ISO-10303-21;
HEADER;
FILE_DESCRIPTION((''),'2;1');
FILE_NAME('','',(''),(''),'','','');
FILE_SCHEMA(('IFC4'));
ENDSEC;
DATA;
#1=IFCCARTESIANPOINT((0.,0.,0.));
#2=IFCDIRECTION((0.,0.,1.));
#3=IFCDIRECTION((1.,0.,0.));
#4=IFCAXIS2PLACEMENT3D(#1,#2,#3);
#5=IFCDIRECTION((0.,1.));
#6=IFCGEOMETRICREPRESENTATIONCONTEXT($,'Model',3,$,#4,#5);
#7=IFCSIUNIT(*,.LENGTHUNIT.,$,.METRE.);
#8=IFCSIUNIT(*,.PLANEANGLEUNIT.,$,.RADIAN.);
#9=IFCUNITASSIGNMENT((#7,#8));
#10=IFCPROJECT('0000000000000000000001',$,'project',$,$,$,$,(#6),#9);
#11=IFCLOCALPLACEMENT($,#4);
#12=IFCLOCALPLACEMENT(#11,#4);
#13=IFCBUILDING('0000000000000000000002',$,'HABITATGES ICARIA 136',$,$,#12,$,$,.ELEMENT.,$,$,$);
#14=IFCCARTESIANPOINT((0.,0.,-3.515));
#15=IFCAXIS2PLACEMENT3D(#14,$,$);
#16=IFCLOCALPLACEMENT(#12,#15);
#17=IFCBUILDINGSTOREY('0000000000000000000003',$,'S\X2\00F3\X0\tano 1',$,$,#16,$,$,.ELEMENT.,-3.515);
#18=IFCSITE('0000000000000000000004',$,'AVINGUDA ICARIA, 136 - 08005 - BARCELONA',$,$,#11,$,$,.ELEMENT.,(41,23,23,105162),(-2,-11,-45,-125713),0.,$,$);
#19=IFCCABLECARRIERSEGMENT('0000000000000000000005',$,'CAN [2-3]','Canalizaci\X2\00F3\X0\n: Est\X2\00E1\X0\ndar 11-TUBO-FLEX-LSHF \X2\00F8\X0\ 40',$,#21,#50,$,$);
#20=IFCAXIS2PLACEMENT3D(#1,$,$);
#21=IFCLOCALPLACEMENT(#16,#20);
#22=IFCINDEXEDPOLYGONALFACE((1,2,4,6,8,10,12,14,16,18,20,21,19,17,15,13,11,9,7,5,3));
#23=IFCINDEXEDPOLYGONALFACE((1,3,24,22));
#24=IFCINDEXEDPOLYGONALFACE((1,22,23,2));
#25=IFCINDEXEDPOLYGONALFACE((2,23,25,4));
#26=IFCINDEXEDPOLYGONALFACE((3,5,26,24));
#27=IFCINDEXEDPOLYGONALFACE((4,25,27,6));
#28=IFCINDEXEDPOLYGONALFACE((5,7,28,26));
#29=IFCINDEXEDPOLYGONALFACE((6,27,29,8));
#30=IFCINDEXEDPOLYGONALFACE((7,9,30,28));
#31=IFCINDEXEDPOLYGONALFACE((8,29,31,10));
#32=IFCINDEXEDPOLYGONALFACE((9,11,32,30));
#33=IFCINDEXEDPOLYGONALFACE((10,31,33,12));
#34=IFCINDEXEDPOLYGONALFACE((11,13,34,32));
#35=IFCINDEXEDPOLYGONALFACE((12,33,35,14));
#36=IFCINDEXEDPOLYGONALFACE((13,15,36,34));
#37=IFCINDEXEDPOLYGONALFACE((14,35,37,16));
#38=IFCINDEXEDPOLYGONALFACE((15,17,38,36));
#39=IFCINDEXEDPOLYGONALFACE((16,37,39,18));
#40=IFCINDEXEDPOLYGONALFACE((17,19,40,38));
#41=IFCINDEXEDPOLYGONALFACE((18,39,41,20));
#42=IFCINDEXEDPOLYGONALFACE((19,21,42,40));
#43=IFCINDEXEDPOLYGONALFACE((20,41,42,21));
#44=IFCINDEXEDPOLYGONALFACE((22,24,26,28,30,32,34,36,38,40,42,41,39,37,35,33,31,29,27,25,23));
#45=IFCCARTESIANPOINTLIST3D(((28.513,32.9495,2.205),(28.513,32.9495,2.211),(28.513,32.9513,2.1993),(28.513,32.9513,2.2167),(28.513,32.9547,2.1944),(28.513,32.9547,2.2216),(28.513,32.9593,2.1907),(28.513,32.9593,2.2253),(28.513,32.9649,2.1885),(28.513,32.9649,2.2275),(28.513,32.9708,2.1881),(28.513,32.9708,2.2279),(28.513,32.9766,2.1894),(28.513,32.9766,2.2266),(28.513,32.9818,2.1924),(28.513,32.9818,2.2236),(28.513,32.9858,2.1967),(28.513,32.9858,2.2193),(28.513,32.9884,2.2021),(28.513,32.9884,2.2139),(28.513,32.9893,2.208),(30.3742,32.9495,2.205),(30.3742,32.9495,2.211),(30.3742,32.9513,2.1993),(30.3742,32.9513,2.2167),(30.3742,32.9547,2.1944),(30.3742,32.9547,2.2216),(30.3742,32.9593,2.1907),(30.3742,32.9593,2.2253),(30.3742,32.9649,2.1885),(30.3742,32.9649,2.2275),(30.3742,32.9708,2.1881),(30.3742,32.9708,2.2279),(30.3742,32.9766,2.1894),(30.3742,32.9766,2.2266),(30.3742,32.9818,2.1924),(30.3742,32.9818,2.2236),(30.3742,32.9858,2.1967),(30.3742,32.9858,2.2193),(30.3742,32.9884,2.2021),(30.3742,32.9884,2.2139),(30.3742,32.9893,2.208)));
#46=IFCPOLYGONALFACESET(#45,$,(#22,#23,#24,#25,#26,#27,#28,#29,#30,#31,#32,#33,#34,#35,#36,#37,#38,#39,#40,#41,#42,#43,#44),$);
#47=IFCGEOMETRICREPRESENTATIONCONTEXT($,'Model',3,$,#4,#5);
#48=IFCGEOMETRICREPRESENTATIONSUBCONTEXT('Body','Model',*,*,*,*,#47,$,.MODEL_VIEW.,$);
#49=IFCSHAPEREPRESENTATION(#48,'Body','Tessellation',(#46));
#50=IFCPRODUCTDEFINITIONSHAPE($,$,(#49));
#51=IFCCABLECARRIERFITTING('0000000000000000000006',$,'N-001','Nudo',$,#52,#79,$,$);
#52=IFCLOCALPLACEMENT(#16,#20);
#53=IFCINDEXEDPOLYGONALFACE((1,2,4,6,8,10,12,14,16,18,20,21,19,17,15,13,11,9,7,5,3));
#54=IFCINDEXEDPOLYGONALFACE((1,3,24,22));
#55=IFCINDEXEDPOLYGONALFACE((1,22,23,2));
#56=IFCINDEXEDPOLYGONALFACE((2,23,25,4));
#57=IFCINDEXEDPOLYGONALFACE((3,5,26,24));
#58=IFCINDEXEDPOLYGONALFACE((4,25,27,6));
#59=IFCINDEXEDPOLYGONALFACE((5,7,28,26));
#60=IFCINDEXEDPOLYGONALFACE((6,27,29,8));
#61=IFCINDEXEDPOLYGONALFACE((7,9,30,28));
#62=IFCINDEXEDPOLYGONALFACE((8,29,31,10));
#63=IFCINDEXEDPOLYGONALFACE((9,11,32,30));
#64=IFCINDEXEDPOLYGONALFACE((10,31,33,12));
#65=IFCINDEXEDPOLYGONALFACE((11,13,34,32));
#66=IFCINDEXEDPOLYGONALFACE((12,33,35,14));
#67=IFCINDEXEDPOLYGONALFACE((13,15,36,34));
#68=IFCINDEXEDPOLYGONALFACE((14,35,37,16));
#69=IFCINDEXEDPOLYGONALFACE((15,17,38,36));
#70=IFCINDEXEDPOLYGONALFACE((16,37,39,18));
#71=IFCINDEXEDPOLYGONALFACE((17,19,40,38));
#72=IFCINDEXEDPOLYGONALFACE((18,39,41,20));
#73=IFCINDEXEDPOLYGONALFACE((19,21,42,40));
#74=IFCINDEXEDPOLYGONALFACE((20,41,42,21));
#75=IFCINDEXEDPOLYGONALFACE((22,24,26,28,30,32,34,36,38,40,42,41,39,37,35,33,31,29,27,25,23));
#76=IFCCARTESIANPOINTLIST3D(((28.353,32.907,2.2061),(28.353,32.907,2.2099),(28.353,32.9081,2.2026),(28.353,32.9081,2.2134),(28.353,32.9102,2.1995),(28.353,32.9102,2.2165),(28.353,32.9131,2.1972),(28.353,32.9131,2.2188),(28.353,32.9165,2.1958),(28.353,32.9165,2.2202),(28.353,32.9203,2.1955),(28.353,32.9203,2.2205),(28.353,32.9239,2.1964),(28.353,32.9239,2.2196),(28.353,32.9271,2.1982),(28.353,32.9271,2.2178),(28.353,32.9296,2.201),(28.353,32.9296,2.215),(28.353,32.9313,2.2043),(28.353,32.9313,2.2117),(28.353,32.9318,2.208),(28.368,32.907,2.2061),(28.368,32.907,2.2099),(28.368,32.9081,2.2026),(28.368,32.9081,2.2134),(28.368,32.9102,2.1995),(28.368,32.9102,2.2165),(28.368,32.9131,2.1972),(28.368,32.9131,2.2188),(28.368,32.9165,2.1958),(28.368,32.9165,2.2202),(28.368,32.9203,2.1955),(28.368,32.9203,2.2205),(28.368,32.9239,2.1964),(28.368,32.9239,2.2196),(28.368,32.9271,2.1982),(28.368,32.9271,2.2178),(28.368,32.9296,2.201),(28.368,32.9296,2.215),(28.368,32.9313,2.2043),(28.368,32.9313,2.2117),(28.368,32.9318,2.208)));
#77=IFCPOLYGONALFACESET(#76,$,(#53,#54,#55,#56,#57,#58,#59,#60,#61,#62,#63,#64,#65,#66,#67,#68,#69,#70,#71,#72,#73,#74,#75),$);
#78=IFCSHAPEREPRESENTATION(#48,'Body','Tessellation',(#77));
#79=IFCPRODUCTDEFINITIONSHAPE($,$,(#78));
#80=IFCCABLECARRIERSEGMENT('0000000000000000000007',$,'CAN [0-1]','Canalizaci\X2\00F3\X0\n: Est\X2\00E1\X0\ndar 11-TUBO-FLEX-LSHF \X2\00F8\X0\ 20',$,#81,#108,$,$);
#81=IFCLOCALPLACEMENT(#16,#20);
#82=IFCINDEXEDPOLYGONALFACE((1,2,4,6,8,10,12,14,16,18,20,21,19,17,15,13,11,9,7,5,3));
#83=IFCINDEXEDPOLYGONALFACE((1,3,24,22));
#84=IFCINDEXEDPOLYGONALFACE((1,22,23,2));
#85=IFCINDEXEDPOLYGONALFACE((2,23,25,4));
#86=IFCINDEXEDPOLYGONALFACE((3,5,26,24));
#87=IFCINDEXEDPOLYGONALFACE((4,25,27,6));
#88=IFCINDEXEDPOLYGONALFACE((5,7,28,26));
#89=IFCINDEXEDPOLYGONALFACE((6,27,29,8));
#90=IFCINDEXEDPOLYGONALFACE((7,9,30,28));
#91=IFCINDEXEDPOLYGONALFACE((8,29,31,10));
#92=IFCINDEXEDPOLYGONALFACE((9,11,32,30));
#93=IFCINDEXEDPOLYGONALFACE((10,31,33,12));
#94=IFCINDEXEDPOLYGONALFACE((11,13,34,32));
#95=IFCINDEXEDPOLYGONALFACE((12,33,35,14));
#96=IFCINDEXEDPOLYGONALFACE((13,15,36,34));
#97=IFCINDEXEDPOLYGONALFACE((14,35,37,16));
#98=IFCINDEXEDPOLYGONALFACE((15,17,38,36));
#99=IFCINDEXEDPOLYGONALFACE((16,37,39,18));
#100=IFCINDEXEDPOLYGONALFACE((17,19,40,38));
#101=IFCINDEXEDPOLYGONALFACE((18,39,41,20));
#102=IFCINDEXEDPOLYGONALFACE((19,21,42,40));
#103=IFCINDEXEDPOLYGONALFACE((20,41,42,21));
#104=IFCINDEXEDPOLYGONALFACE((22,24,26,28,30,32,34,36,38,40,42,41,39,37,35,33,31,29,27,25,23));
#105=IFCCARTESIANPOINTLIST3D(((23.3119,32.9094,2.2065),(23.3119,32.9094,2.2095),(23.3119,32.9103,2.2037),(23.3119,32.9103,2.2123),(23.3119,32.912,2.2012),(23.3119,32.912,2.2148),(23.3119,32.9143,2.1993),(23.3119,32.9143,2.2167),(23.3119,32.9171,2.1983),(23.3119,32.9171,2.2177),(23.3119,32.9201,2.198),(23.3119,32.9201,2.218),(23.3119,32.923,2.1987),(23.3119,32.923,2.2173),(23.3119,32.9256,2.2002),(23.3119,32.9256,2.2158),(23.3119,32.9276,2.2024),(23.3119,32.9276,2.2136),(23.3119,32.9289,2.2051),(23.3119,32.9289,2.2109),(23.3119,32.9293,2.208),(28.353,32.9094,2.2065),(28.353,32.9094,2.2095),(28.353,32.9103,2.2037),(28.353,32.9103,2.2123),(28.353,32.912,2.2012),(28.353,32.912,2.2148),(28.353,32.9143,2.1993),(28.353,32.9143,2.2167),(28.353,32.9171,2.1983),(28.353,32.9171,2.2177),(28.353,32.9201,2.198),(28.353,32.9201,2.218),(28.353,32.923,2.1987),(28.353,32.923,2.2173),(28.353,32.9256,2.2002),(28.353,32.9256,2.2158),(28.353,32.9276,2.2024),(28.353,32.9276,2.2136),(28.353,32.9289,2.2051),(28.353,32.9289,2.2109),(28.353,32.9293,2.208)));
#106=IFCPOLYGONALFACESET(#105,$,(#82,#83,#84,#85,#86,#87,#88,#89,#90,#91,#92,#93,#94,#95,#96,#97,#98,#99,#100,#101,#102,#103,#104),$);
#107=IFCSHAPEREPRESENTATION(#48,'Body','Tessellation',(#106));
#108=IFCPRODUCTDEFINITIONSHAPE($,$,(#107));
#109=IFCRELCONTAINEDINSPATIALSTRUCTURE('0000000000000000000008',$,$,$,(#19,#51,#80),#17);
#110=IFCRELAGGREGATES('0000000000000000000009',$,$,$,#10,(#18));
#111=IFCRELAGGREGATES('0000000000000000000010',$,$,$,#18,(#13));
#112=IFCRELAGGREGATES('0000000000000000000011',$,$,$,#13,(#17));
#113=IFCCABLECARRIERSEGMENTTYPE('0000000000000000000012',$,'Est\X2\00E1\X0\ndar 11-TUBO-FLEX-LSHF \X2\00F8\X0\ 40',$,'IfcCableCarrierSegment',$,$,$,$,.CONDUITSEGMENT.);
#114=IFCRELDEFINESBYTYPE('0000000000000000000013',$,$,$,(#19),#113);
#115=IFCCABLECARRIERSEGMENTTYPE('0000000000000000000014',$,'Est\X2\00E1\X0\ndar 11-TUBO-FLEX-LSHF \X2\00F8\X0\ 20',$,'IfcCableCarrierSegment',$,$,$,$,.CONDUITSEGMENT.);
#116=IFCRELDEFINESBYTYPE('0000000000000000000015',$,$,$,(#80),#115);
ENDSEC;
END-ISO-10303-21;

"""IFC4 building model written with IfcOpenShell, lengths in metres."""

from ifc_helpers import new_model, si_unit, direction, frame, origin_with_axes, origin_2d_with_axis, place, context, subcontext, project, spatial, circle, extrude, source, transform, mapped, type_object, element, save


model = new_model("IFC4")

# Units and contexts
model_context_1 = context("Model", 3, world=origin_with_axes(), true_north=direction((0.0, 1.0)))
model_context_2 = context("Model", 3, world=origin_with_axes(), true_north=direction((0.0, 1.0)))
body_context_1 = subcontext(model_context_2, "Body", "Model", "MODEL_VIEW")
ifc_project = project(units=[si_unit("LENGTHUNIT", "METRE"), si_unit("PLANEANGLEUNIT", "RADIAN")], contexts=[model_context_1])

# Site, building, storey
site_placement = place(None, origin_with_axes())
site = spatial("IfcSite", under=ifc_project, at=site_placement, Name="AVINGUDA ICARIA, 136 - 08005 - BARCELONA", CompositionType="ELEMENT", RefLatitude=(41, 23, 23, 105162), RefLongitude=(-2, -11, -45, -125713), RefElevation=0.0)
building_placement = place(site_placement, origin_with_axes())
building = spatial("IfcBuilding", under=site, at=building_placement, Name="HABITATGES ICARIA 136", CompositionType="ELEMENT")
storey_placement = place(building_placement, frame((0.0, 0.0, -3.515)))
storey = spatial("IfcBuildingStorey", under=building, at=storey_placement, Name="Sótano 1", CompositionType="ELEMENT", Elevation=-3.515)

# Shared definitions
placement_1 = place(None, origin_with_axes())
placement_2 = place(placement_1, origin_with_axes())
placement_3 = place(placement_2, frame((0.0, 0.0, -3.515)))

# Cable carrier segment
cable_carrier_segment_type_1 = type_object("IfcCableCarrierSegmentType", Name="Estándar 11-TUBO-FLEX-LSHF ø 40", ApplicableOccurrence="IfcCableCarrierSegment", PredefinedType="CONDUITSEGMENT")
cable_carrier_segment_1_placement = place(placement_3, origin_with_axes())
element("IfcCableCarrierSegment", 1, at=cable_carrier_segment_1_placement, inside=storey, type_object=cable_carrier_segment_type_1, Name="CAN [2-3]", Description="Canalización: Estándar 11-TUBO-FLEX-LSHF ø 40", context=body_context_1, shape_type="SweptSolid", body=[
    extrude(circle(Radius=0.02, at=origin_2d_with_axis()), frame((28.513, 32.9693, 2.208), z_axis=(1.0, 0.0, 0.0), x_axis=(0.0, 1.0, 0.0)), (0.0, 0.0, 1.0), 1.8612),
])

# Cable carrier fitting
shared_shape_1 = source(origin_with_axes(), body_context_1, "Body", "SweptSolid", [
    extrude(circle(Radius=0.0125, at=origin_2d_with_axis()), frame((0.0, -0.015, 0.0), z_axis=(0.0, 1.0, 0.0), x_axis=(-1.0, 0.0, 0.0)), (0.0, 0.0, 1.0), 0.015),
])
cable_carrier_fitting_1_placement = place(placement_3, origin_with_axes())
element("IfcCableCarrierFitting", 2, at=cable_carrier_fitting_1_placement, inside=storey, Name="N-001", Description="Nudo", context=body_context_1, shape_type="MappedRepresentation", body=[
    mapped(shared_shape_1, transform((28.368, 32.9193, 2.208), x_axis=(0.0, -1.0, 0.0), y_axis=(1.0, 0.0, 0.0), z_axis=(0.0, 0.0, 1.0), scale=1.0)),
])

# Cable carrier segment
cable_carrier_segment_type_2 = type_object("IfcCableCarrierSegmentType", Name="Estándar 11-TUBO-FLEX-LSHF ø 20", ApplicableOccurrence="IfcCableCarrierSegment", PredefinedType="CONDUITSEGMENT")
cable_carrier_segment_2_placement = place(placement_3, origin_with_axes())
element("IfcCableCarrierSegment", 3, at=cable_carrier_segment_2_placement, inside=storey, type_object=cable_carrier_segment_type_2, Name="CAN [0-1]", Description="Canalización: Estándar 11-TUBO-FLEX-LSHF ø 20", context=body_context_1, shape_type="SweptSolid", body=[
    extrude(circle(Radius=0.01, at=origin_2d_with_axis()), frame((23.3119, 32.9193, 2.208), z_axis=(1.0, 0.0, 0.0), x_axis=(0.0, 1.0, 0.0)), (0.0, 0.0, 1.0), 5.0411),
])

save(model, "model.ifc")
